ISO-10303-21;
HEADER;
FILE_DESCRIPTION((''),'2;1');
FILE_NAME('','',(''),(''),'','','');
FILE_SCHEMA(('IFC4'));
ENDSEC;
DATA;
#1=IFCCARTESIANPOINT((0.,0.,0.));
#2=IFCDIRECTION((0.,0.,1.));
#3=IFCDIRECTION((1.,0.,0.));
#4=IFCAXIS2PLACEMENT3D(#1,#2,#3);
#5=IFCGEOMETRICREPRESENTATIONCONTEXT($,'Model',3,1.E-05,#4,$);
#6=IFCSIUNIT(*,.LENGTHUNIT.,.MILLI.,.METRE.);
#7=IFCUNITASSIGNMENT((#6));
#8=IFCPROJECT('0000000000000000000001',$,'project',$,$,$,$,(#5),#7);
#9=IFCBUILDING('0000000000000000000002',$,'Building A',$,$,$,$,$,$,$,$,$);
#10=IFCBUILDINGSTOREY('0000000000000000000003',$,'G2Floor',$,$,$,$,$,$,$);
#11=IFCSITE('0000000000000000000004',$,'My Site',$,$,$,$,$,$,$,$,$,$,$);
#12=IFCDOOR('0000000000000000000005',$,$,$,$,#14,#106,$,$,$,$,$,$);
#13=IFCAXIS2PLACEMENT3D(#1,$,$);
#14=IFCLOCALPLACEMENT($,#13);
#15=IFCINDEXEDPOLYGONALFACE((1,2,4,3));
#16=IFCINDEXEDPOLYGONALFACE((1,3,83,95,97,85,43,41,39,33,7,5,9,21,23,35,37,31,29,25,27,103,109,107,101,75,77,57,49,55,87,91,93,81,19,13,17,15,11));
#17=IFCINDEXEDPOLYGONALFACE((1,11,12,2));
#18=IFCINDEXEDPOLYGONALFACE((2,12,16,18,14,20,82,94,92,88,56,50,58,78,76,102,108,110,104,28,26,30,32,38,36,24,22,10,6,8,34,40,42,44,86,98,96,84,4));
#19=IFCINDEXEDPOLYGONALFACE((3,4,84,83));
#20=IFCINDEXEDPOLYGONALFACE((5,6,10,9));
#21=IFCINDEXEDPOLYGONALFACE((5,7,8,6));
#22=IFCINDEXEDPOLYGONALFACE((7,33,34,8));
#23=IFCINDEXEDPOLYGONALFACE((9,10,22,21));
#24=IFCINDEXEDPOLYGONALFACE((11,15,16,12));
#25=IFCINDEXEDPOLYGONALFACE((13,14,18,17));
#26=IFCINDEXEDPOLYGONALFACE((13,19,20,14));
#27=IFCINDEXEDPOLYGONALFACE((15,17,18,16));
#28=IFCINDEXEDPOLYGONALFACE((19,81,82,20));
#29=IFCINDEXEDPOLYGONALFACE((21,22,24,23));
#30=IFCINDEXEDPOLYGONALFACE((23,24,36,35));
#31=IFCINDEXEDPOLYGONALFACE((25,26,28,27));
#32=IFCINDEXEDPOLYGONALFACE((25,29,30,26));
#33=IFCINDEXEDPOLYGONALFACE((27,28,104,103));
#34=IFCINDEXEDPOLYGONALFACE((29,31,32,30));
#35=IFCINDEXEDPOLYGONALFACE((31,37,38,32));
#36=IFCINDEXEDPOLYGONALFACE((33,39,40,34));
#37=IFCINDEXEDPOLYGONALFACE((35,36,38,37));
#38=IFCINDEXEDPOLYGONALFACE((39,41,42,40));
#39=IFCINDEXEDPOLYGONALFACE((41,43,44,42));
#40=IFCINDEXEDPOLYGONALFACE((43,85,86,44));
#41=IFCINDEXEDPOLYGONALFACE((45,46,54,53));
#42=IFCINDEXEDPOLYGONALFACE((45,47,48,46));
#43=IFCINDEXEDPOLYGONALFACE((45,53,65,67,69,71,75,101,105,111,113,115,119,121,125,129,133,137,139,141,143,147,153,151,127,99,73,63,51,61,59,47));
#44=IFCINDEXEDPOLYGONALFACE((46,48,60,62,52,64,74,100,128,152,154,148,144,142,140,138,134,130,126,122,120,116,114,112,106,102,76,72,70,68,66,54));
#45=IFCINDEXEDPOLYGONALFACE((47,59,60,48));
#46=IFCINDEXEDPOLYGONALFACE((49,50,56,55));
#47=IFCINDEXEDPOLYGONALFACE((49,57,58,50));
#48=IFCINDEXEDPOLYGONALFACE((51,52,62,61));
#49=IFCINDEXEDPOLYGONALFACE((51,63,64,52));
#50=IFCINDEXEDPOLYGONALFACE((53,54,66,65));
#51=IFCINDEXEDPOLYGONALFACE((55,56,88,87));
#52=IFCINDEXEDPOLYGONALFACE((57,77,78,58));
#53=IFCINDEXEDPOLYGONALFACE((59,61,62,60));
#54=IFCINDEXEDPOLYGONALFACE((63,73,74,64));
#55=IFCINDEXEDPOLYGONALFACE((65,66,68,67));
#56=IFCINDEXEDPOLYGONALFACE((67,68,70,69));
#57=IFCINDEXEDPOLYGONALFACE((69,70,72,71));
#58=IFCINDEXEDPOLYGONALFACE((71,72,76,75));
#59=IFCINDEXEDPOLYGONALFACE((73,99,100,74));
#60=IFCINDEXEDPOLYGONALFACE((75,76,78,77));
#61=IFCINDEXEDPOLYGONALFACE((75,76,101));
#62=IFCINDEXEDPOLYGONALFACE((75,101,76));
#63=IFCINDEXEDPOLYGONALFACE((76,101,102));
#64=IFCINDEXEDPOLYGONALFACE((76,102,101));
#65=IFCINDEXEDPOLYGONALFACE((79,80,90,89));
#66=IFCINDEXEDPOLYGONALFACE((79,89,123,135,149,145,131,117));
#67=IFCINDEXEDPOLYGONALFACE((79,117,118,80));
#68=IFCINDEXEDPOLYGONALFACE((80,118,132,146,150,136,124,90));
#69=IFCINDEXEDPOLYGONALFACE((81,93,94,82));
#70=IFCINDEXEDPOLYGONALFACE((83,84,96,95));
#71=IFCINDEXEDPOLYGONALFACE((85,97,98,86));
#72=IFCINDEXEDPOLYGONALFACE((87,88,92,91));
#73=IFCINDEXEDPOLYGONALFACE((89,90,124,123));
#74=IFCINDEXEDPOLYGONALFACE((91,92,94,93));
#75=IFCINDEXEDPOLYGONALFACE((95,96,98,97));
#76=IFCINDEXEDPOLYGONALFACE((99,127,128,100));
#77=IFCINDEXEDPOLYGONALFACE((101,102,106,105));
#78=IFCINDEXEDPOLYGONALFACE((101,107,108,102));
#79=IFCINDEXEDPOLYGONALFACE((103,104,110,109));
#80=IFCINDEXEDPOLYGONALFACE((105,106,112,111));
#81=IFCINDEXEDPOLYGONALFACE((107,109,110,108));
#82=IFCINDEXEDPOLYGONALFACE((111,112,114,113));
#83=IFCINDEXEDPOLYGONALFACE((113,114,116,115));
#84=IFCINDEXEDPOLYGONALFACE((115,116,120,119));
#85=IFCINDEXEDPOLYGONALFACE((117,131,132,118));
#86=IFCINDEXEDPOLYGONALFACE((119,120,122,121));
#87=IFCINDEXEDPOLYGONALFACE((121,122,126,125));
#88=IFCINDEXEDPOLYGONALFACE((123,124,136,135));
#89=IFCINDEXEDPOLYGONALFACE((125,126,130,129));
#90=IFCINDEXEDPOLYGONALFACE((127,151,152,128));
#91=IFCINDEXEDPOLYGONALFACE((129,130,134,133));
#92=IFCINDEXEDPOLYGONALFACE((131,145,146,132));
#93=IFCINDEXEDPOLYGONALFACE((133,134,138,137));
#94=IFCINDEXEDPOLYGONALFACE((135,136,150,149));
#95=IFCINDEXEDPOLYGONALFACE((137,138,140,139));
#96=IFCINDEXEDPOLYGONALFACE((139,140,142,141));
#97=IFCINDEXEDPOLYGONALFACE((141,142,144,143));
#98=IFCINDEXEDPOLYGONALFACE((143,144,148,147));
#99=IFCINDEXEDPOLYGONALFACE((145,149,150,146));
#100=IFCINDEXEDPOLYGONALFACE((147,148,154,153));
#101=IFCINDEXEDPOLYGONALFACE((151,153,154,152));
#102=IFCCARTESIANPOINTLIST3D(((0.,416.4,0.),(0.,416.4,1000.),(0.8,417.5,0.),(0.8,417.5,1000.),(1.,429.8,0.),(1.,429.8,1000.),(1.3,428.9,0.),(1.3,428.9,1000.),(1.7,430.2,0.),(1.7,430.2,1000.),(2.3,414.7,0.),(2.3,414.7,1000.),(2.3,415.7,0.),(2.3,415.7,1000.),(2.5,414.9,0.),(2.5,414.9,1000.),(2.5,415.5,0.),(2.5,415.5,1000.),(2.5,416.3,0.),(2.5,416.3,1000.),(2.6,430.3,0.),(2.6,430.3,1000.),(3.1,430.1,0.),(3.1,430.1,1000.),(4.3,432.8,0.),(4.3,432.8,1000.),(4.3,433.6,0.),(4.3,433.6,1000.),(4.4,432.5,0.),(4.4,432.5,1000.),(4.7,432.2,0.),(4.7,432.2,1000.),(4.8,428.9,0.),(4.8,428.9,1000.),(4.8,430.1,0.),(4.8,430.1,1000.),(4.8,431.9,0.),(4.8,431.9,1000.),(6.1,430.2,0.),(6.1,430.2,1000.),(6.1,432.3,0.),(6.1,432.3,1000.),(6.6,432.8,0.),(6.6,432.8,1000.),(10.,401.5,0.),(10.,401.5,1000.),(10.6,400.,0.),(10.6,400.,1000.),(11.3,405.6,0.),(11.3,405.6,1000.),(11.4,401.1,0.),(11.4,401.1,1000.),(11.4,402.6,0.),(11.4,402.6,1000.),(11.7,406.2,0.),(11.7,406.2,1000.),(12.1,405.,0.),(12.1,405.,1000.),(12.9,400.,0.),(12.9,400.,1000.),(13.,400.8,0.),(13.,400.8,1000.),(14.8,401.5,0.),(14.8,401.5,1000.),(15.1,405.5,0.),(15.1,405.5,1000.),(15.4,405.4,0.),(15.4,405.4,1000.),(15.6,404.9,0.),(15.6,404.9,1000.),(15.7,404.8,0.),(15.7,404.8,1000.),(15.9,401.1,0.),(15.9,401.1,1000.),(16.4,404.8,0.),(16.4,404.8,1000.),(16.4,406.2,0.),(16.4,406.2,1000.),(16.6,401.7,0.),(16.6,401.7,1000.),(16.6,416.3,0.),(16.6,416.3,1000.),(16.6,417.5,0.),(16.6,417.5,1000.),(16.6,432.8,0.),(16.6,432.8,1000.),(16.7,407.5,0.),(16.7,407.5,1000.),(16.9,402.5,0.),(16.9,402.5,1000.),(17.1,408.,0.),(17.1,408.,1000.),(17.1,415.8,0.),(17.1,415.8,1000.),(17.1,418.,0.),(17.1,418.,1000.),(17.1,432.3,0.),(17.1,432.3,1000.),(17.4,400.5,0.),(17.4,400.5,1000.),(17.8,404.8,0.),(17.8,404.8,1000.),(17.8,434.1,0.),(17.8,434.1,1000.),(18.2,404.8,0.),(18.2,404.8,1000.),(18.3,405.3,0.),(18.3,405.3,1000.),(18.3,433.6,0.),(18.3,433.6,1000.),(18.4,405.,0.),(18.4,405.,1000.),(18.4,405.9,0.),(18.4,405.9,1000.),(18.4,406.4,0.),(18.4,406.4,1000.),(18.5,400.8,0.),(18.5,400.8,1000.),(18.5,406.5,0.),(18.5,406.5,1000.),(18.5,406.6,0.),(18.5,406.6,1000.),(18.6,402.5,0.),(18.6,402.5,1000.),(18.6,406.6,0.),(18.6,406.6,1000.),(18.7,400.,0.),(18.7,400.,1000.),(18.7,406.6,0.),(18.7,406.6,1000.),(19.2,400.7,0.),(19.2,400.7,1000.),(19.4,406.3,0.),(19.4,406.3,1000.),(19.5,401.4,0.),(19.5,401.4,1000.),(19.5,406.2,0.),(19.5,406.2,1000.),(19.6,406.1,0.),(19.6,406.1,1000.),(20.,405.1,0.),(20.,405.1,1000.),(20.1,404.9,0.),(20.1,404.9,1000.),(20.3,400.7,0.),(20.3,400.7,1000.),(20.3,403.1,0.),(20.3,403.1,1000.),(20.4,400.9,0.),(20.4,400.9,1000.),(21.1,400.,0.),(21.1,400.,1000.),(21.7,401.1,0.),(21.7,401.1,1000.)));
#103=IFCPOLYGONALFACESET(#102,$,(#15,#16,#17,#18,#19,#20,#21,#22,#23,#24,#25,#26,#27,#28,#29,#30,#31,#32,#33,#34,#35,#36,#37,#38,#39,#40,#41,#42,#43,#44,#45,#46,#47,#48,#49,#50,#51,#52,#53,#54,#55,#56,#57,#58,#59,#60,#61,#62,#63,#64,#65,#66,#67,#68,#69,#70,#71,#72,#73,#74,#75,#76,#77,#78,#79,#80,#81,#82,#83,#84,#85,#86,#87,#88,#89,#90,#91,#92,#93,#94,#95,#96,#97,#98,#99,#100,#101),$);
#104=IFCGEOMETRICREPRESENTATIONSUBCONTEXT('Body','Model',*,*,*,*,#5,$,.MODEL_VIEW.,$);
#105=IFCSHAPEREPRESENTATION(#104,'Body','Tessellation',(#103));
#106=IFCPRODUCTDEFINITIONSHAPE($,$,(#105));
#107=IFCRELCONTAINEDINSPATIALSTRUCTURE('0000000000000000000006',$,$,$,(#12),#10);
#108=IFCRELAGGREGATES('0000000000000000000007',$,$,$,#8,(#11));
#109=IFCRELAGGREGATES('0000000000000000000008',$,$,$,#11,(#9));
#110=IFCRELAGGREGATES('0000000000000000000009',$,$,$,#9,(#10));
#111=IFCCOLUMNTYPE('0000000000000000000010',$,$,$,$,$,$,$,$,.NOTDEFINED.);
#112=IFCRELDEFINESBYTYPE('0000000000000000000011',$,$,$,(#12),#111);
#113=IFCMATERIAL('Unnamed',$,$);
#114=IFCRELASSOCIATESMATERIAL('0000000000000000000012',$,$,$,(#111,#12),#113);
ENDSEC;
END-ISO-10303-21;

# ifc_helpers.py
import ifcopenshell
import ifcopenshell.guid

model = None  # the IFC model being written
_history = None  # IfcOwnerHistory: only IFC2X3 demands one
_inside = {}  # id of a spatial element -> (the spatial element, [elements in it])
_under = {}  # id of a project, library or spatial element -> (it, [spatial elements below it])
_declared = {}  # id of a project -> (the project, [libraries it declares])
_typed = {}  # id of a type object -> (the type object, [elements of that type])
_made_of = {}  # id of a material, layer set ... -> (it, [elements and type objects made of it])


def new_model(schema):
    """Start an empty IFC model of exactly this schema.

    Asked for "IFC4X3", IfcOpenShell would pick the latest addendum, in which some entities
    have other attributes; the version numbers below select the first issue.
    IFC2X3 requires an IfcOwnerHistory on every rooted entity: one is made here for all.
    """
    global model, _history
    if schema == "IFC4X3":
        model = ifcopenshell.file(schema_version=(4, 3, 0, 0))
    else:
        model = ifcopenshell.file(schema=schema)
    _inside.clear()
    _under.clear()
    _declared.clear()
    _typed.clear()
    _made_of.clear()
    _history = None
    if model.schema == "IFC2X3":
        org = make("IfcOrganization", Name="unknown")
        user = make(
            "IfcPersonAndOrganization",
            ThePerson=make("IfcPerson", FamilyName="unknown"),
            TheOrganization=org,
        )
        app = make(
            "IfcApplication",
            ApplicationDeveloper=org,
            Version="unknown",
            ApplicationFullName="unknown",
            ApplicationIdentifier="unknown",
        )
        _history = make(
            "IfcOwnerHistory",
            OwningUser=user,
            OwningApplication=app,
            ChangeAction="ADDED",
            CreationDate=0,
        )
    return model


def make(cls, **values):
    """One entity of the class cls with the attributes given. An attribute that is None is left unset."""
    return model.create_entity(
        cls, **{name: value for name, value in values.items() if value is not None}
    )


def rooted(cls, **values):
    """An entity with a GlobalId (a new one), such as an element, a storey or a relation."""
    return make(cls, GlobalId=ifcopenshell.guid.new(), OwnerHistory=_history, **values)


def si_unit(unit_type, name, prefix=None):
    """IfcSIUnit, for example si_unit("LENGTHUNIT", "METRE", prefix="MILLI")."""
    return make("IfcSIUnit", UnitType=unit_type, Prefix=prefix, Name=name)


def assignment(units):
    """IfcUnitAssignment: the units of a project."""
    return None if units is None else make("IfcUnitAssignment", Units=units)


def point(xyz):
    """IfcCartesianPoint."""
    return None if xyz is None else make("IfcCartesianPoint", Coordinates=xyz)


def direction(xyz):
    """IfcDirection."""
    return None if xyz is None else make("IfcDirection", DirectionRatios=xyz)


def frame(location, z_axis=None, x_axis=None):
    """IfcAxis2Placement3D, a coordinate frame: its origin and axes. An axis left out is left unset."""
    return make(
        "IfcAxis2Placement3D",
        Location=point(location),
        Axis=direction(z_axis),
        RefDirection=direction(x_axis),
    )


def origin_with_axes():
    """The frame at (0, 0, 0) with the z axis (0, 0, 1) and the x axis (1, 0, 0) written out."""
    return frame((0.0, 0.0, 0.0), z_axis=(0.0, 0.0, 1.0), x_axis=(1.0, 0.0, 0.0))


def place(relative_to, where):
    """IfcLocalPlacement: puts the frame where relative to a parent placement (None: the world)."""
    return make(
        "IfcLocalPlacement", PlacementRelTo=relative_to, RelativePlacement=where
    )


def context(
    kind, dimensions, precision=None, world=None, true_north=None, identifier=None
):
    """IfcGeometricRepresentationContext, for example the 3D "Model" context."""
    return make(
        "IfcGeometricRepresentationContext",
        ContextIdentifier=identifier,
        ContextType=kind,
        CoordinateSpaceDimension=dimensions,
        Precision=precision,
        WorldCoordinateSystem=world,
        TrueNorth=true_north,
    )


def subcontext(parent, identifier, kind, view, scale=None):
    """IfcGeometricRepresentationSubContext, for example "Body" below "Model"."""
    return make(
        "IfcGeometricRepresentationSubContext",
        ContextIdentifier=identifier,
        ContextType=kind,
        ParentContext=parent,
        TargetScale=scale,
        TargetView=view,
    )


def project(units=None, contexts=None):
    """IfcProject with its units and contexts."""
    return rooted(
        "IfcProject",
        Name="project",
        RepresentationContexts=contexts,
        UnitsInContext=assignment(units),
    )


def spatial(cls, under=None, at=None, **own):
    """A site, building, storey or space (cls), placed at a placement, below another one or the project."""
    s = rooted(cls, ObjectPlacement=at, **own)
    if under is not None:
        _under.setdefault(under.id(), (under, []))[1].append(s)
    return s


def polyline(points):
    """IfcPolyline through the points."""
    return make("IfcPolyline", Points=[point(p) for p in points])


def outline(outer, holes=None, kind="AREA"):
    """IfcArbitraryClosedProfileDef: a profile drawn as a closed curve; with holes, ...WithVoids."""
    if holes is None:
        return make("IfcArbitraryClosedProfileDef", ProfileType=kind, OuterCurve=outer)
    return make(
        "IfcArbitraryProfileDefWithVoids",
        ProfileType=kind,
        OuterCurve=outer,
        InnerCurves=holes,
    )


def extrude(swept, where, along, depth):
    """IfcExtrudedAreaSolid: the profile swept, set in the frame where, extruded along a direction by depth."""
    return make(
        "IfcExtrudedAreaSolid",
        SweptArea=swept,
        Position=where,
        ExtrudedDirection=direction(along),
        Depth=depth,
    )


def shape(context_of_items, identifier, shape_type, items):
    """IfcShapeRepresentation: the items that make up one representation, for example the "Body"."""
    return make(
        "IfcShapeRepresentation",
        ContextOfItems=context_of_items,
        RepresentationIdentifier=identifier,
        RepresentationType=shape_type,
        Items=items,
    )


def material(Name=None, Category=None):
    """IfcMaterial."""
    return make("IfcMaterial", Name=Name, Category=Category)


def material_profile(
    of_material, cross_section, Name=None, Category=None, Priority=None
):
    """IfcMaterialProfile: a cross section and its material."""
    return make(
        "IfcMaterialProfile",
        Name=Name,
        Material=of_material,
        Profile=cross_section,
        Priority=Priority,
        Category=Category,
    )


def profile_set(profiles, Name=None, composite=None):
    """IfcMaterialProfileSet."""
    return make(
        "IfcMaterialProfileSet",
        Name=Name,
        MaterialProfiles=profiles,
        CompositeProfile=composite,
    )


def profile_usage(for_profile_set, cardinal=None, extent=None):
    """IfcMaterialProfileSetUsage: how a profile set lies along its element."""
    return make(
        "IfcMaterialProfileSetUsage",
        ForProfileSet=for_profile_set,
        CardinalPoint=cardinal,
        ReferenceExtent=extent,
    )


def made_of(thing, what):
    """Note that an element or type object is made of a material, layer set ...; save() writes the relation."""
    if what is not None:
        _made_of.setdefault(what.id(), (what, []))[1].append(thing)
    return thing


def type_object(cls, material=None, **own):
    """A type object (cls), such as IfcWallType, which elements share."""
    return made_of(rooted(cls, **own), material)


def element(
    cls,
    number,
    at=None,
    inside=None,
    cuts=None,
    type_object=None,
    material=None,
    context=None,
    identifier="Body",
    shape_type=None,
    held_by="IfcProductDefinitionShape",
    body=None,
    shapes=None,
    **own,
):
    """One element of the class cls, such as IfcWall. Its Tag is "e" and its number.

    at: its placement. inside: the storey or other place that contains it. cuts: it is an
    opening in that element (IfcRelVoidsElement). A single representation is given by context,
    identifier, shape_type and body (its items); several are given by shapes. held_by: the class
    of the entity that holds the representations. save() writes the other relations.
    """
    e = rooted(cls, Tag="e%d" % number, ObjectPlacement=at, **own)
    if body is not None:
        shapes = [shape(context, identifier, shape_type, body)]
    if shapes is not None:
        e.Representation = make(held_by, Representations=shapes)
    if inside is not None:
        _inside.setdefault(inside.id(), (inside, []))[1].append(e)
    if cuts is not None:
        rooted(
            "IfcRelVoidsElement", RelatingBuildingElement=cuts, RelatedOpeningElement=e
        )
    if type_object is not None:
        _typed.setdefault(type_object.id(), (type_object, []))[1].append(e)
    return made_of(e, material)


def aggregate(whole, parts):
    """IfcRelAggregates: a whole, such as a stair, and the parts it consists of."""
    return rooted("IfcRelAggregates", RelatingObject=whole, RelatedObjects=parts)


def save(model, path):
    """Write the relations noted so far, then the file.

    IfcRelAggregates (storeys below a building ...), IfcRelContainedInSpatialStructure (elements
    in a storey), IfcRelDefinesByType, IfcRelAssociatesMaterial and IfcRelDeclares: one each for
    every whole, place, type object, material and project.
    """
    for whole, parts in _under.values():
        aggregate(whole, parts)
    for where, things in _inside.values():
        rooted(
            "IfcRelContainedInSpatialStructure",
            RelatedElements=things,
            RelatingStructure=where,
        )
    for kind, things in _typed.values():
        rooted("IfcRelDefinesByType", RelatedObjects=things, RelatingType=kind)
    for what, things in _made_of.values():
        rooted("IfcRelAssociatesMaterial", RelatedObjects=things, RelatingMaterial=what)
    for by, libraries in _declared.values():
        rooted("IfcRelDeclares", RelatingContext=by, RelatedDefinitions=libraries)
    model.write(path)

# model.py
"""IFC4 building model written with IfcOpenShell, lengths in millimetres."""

from ifc_helpers import new_model, si_unit, origin_with_axes, place, context, subcontext, project, spatial, polyline, outline, extrude, material, material_profile, profile_set, profile_usage, type_object, element, save


model = new_model("IFC4")

# Units and contexts
model_context = context("Model", 3, precision=1e-05, world=origin_with_axes())
body_context = subcontext(model_context, "Body", "Model", "MODEL_VIEW")
ifc_project = project(units=[si_unit("LENGTHUNIT", "METRE", prefix="MILLI")], contexts=[model_context])

# Site, building, storey
site = spatial("IfcSite", under=ifc_project, Name="My Site")
building = spatial("IfcBuilding", under=site, Name="Building A")
storey = spatial("IfcBuildingStorey", under=building, Name="G2Floor")

# Door
ifc_material_1 = material(Name="Unnamed")
ifc_material_profile_1 = material_profile(ifc_material_1, outline(polyline([(4.3, 433.6), (4.3, 432.8), (4.4, 432.5), (4.7, 432.2), (4.8, 431.9), (4.8, 430.1), (3.1, 430.1), (2.6, 430.3), (1.7, 430.2), (1.0, 429.8), (1.3, 428.9), (4.8, 428.9), (6.1, 430.2), (6.1, 432.3), (6.6, 432.8), (16.6, 432.8), (17.1, 432.3), (17.1, 418.0), (17.1, 418.0), (16.6, 417.5), (0.8, 417.5), (0.0, 416.4), (2.3, 414.7), (2.5, 414.9), (2.5, 415.5), (2.3, 415.7), (2.5, 416.3), (16.6, 416.3), (17.1, 415.8), (17.1, 408.0), (16.7, 407.5), (11.7, 406.2), (11.3, 405.6), (12.1, 405.0), (16.4, 406.2), (16.4, 404.8), (17.8, 404.8), (18.3, 405.3), (18.3, 433.6), (17.8, 434.1), (4.8, 434.1)]), holes=[polyline([(18.4, 405.0), (18.4, 405.9), (18.4, 406.4), (18.5, 406.5), (18.5, 406.6), (18.6, 406.6), (18.7, 406.6), (19.4, 406.3), (19.5, 406.2), (19.6, 406.1), (20.0, 405.1), (20.1, 404.9), (20.3, 403.1), (21.7, 401.1), (21.1, 400.0), (18.7, 400.0), (17.4, 400.5), (15.9, 401.1), (14.8, 401.5), (11.4, 401.1), (13.0, 400.8), (12.9, 400.0), (10.6, 400.0), (10.0, 401.5), (11.4, 402.6), (15.1, 405.5), (15.4, 405.4), (15.6, 404.9), (15.7, 404.8), (18.2, 404.8), (18.4, 404.9)]), polyline([(18.6, 402.5), (19.5, 401.4), (20.4, 400.9), (20.3, 400.7), (19.2, 400.7), (18.5, 400.8), (16.6, 401.7), (16.9, 402.5), (18.1, 402.7)])]))
ifc_profile_set_1 = profile_set([ifc_material_profile_1], Name="Unnamed")
ifc_profile_usage_1 = profile_usage(ifc_profile_set_1)
column_type_1 = type_object("IfcColumnType", PredefinedType="NOTDEFINED", material=ifc_profile_set_1)
door_1_placement = place(None, origin_with_axes())
element("IfcDoor", 1, at=door_1_placement, inside=storey, type_object=column_type_1, material=ifc_profile_usage_1, context=body_context, shape_type="SweptSolid", body=[
    extrude(outline(polyline([(4.3, 433.6), (4.3, 432.8), (4.4, 432.5), (4.7, 432.2), (4.8, 431.9), (4.8, 430.1), (3.1, 430.1), (2.6, 430.3), (1.7, 430.2), (1.0, 429.8), (1.3, 428.9), (4.8, 428.9), (6.1, 430.2), (6.1, 432.3), (6.6, 432.8), (16.6, 432.8), (17.1, 432.3), (17.1, 418.0), (17.1, 418.0), (16.6, 417.5), (0.8, 417.5), (0.0, 416.4), (2.3, 414.7), (2.5, 414.9), (2.5, 415.5), (2.3, 415.7), (2.5, 416.3), (16.6, 416.3), (17.1, 415.8), (17.1, 408.0), (16.7, 407.5), (11.7, 406.2), (11.3, 405.6), (12.1, 405.0), (16.4, 406.2), (16.4, 404.8), (17.8, 404.8), (18.3, 405.3), (18.3, 433.6), (17.8, 434.1), (4.8, 434.1)]), holes=[polyline([(18.4, 405.0), (18.4, 405.9), (18.4, 406.4), (18.5, 406.5), (18.5, 406.6), (18.6, 406.6), (18.7, 406.6), (19.4, 406.3), (19.5, 406.2), (19.6, 406.1), (20.0, 405.1), (20.1, 404.9), (20.3, 403.1), (21.7, 401.1), (21.1, 400.0), (18.7, 400.0), (17.4, 400.5), (15.9, 401.1), (14.8, 401.5), (11.4, 401.1), (13.0, 400.8), (12.9, 400.0), (10.6, 400.0), (10.0, 401.5), (11.4, 402.6), (15.1, 405.5), (15.4, 405.4), (15.6, 404.9), (15.7, 404.8), (18.2, 404.8), (18.4, 404.9)]), polyline([(18.6, 402.5), (19.5, 401.4), (20.4, 400.9), (20.3, 400.7), (19.2, 400.7), (18.5, 400.8), (16.6, 401.7), (16.9, 402.5), (18.1, 402.7)])]), origin_with_axes(), (0.0, 0.0, 1.0), 1000.0),
])

save(model, "model.ifc")
